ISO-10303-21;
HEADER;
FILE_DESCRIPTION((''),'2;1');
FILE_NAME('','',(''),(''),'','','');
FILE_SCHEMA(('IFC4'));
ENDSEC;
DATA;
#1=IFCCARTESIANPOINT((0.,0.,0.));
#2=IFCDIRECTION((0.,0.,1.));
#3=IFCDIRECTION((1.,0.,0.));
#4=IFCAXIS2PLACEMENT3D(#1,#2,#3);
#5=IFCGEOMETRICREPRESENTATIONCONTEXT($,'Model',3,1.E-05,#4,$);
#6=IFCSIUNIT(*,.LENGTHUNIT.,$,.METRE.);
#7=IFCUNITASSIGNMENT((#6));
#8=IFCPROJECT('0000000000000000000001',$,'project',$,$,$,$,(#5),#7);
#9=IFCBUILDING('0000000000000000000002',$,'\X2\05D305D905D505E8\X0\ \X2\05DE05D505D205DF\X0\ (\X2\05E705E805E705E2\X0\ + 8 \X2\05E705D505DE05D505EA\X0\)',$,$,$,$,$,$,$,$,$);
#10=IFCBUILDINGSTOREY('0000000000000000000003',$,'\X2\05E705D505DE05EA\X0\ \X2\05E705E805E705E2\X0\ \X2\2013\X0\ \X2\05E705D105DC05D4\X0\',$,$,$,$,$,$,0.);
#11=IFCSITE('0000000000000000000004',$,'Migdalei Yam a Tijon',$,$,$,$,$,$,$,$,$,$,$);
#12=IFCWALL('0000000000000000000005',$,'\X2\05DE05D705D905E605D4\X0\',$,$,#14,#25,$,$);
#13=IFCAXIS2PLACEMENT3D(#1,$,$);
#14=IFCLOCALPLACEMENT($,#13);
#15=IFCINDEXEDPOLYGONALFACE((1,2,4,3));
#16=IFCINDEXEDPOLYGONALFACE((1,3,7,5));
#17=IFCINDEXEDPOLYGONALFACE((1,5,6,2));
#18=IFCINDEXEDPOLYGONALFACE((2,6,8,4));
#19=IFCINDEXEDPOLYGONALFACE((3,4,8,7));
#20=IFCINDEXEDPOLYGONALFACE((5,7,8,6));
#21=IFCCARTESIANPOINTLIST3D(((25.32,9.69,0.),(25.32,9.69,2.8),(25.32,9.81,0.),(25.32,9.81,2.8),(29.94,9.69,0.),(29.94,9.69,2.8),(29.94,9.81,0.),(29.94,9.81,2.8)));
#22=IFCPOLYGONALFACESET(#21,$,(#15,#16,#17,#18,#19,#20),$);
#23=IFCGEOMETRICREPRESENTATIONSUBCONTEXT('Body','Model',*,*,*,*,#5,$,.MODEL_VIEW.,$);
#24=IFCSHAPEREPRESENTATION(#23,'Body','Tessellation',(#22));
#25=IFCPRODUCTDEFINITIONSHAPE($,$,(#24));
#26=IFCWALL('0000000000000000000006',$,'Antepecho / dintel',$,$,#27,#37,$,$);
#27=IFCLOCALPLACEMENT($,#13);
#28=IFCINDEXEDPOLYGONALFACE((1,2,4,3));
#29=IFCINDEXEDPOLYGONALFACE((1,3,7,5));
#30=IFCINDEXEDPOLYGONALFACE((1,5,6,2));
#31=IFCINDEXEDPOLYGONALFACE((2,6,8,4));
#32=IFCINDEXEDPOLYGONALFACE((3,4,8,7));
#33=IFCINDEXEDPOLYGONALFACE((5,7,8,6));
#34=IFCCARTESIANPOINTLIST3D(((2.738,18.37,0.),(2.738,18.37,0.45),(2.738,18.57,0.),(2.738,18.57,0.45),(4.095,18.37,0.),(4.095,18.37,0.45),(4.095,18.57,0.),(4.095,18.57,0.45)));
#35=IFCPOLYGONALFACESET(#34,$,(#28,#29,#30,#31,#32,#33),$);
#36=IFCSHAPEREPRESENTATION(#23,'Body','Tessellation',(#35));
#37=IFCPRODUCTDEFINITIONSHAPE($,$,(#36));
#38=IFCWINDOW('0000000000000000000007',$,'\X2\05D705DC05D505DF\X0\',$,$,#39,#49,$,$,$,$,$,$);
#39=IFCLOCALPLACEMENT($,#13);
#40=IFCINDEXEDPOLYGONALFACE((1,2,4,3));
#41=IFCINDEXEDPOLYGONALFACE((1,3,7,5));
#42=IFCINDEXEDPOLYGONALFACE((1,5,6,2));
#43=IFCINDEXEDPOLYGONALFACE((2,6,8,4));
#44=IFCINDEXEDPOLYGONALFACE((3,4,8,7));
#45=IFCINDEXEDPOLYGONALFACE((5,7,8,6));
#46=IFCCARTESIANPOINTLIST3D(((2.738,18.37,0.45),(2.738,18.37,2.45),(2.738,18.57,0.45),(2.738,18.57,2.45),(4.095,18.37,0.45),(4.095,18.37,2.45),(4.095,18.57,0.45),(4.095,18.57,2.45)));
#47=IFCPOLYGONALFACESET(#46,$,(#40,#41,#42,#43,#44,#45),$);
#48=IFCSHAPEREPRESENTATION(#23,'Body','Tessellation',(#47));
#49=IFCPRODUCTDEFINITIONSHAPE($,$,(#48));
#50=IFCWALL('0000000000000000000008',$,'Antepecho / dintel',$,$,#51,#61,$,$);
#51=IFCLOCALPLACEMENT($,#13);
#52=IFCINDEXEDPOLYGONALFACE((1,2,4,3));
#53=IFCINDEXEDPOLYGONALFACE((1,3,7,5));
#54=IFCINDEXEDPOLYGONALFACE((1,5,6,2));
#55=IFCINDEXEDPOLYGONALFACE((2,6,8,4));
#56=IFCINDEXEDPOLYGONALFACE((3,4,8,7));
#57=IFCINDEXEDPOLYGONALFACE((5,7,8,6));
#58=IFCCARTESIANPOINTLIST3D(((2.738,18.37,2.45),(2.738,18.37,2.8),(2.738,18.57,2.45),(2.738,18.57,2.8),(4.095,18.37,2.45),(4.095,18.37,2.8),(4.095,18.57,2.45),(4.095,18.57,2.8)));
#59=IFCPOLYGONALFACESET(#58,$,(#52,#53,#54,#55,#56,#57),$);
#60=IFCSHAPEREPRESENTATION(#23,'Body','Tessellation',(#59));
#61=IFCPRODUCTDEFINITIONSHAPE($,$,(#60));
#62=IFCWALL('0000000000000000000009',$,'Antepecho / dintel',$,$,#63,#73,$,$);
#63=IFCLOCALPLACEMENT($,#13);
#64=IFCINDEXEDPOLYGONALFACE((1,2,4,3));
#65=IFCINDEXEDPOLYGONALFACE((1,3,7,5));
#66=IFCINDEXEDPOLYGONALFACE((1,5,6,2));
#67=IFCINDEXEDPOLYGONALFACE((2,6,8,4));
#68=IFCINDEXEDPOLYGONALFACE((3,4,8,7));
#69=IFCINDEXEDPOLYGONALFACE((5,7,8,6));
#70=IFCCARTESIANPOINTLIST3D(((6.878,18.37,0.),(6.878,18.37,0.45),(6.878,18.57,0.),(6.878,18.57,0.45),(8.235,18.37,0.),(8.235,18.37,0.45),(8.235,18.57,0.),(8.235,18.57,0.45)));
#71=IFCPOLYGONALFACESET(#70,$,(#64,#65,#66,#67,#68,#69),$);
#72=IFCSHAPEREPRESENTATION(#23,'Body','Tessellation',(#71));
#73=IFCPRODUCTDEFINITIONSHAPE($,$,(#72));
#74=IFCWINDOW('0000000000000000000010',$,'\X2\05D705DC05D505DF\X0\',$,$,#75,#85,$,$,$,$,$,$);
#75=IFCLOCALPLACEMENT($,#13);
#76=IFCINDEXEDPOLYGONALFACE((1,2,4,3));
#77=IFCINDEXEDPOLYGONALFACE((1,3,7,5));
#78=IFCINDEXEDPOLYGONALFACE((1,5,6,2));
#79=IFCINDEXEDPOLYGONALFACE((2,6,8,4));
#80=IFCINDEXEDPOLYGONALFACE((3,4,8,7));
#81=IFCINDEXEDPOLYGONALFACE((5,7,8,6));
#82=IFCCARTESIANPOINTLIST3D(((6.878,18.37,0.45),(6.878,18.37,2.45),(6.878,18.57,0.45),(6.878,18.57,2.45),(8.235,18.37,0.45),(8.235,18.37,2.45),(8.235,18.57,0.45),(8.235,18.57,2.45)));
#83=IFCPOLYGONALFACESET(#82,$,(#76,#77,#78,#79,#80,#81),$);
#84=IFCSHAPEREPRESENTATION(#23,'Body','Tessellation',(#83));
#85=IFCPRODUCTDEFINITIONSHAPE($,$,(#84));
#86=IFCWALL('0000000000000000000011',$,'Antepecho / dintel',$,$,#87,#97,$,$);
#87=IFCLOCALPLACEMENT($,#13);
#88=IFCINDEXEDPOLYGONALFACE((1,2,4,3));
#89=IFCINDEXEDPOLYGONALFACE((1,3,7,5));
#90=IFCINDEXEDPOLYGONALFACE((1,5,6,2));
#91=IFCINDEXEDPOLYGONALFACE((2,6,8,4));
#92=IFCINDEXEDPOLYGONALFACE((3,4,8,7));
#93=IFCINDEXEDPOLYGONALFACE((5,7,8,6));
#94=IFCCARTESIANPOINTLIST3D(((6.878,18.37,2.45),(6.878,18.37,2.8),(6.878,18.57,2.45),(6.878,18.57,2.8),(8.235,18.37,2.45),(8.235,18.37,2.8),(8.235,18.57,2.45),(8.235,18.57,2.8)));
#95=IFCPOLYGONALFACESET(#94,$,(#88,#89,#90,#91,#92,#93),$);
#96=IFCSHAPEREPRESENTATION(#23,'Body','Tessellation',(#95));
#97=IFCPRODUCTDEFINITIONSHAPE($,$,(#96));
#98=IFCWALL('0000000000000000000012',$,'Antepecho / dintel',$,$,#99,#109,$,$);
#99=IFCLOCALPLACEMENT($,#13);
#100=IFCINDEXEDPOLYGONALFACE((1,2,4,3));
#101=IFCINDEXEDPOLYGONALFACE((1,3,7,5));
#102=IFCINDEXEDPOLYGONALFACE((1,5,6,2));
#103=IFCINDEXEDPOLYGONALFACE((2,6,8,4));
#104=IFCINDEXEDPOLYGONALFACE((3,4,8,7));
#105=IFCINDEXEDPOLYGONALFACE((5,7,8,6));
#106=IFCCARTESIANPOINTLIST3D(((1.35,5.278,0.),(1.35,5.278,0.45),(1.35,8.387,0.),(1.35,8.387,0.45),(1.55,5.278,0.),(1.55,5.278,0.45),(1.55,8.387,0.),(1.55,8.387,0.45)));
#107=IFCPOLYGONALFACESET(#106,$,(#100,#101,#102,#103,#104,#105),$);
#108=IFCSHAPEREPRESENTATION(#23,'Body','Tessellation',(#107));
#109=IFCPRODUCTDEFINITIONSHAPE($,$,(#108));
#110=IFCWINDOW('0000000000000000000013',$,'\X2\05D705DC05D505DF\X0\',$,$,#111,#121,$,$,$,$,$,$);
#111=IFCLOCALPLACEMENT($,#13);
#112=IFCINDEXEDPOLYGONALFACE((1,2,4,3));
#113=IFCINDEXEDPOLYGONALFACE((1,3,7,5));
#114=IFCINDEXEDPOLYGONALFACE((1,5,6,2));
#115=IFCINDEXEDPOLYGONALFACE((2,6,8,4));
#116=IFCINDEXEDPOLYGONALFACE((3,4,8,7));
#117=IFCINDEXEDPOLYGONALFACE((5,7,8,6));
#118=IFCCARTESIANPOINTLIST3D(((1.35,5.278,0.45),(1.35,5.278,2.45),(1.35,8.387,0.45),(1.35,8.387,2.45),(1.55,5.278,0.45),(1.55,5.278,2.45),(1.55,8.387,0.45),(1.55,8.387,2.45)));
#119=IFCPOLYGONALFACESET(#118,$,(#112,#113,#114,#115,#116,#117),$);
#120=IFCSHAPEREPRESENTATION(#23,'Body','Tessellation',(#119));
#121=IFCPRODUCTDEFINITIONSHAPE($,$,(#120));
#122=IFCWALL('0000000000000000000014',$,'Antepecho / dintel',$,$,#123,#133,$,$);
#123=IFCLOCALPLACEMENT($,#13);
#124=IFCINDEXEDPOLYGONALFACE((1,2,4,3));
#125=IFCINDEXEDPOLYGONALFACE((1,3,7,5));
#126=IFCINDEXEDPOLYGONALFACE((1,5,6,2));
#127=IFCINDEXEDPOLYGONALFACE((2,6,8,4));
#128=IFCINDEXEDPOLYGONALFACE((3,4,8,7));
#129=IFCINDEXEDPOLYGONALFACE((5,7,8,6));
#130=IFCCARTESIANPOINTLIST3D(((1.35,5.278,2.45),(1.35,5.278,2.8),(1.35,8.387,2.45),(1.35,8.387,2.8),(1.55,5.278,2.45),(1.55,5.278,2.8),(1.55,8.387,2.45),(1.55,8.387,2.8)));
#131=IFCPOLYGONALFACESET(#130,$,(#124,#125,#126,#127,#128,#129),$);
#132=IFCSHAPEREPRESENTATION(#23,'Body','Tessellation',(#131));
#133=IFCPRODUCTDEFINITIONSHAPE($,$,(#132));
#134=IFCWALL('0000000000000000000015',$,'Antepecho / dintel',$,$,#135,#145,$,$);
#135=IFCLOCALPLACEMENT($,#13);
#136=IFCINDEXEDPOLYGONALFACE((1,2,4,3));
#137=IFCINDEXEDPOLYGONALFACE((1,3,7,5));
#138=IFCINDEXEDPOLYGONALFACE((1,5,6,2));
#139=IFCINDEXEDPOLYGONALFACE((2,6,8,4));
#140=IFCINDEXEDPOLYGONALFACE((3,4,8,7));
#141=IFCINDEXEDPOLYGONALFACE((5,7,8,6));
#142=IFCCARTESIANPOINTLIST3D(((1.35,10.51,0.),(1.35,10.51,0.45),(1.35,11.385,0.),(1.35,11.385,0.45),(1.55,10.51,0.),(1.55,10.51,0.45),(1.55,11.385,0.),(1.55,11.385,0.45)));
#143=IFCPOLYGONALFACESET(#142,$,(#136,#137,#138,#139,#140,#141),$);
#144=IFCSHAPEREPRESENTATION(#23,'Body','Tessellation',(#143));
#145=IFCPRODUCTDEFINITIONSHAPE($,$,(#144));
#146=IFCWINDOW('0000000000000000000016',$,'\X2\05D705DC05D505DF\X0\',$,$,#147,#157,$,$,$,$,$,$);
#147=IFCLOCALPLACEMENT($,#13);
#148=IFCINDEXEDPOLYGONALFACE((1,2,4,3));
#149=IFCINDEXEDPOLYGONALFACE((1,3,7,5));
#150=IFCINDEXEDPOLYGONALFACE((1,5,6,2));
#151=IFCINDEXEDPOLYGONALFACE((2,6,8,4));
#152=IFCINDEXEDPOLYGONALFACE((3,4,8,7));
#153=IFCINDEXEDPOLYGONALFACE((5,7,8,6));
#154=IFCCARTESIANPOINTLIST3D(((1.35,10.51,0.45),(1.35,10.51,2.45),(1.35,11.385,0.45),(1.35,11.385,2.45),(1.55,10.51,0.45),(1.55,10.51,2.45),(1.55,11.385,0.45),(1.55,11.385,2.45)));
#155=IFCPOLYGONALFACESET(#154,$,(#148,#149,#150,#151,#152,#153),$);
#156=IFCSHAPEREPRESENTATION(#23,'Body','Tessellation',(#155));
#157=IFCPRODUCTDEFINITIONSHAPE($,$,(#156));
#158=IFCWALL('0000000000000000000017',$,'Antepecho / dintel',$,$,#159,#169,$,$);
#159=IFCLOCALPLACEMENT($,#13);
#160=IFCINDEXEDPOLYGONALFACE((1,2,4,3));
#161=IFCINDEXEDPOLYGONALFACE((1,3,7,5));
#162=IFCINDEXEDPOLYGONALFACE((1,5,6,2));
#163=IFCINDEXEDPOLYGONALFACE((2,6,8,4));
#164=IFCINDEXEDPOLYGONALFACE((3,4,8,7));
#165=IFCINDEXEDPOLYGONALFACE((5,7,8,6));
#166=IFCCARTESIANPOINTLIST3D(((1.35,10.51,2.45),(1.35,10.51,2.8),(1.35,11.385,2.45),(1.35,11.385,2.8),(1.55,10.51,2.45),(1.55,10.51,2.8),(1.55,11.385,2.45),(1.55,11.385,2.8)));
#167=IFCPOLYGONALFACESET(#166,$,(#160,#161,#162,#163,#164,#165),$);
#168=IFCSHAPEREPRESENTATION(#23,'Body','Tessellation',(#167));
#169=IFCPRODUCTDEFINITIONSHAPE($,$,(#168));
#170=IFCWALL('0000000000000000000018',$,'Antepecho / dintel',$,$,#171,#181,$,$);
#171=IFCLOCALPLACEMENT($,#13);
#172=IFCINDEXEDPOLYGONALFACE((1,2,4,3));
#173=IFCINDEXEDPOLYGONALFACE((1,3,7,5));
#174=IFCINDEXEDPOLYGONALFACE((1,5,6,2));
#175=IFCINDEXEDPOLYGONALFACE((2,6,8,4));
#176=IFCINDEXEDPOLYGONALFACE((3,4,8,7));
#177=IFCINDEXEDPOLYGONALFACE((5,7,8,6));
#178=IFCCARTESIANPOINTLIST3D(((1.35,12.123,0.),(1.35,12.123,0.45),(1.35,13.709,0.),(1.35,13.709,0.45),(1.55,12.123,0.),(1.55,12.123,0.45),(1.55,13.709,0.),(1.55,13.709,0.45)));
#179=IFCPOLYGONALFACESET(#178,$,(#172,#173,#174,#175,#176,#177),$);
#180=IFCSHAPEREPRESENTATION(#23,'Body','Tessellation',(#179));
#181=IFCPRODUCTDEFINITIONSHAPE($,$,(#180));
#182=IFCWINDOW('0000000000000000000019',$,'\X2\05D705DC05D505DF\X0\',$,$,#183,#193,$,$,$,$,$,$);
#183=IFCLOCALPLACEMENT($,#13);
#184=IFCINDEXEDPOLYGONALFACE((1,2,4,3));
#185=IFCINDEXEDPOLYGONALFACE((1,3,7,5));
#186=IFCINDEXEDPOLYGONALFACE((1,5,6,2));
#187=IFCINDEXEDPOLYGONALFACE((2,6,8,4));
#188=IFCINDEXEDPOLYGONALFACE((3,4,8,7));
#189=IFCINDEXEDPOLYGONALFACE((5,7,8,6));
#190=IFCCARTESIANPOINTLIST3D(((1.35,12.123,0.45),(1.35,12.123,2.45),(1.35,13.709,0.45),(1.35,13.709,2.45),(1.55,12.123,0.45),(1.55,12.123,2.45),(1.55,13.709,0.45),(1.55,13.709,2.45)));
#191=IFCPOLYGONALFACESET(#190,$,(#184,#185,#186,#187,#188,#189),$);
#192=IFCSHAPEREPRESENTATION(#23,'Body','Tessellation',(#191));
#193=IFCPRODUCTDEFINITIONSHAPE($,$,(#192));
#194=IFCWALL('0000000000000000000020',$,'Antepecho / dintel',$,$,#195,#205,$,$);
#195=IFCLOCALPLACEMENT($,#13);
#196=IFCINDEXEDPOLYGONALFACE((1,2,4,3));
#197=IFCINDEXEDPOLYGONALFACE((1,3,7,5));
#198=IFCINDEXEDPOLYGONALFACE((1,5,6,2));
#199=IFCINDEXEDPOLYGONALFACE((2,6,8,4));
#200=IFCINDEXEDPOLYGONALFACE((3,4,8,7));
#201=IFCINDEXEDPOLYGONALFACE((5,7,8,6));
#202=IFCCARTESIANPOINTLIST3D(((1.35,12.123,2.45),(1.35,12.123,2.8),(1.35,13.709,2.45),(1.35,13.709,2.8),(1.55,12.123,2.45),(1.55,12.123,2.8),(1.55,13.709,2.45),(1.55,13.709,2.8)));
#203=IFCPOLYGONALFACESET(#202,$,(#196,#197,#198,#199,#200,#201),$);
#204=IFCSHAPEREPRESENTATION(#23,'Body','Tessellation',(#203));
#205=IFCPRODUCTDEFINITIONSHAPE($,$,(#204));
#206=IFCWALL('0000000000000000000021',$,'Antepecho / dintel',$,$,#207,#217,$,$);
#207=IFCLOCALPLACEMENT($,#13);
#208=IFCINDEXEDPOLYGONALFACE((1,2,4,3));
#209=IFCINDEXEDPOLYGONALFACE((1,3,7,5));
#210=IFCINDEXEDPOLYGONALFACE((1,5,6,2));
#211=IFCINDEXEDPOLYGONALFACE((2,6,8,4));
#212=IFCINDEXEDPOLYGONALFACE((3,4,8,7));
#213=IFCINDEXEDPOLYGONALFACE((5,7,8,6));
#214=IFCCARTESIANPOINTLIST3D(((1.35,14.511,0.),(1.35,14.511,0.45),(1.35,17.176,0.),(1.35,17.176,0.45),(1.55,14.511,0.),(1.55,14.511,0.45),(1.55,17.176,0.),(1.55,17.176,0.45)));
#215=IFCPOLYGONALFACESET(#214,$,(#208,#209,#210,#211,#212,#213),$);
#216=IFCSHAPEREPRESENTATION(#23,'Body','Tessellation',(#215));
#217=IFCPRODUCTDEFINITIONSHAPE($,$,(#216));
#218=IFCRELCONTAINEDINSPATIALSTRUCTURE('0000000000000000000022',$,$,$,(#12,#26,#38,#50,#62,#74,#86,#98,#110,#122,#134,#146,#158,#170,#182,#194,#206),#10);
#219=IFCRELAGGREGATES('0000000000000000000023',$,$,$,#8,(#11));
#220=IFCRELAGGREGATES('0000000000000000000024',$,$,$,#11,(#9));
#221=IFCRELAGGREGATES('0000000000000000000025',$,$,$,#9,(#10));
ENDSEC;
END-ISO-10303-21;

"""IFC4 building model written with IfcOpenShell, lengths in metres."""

from ifc_helpers import new_model, si_unit, frame, origin_with_axes, context, subcontext, project, spatial, line, indexed_curve, outline, extrude, element, save


model = new_model("IFC4")

# Units and contexts
model_context = context("Model", 3, precision=1e-05, world=origin_with_axes())
body_context = subcontext(model_context, "Body", "Model", "MODEL_VIEW")
ifc_project = project(units=[si_unit("LENGTHUNIT", "METRE")], contexts=[model_context])

# Site, building, storey
site = spatial("IfcSite", under=ifc_project, Name="Migdalei Yam a Tijon")
building = spatial("IfcBuilding", under=site, Name="דיור מוגן (קרקע + 8 קומות)")
storey = spatial("IfcBuildingStorey", under=building, Name="קומת קרקע – קבלה", Elevation=0.0)

# Walls
element("IfcWall", 1, inside=storey, Name="מחיצה", context=body_context, shape_type="SweptSolid", body=[
    extrude(outline(indexed_curve([(0.0, 0.0), (4.62, 0.0), (4.62, 0.12), (0.0, 0.12)], segments=[line(1, 2, 3, 4, 1)])), frame((25.32, 9.69, 0.0), z_axis=(0.0, 0.0, 1.0), x_axis=(1.0, 0.0, 0.0)), (0.0, 0.0, 1.0), 2.8),
])
element("IfcWall", 2, inside=storey, Name="Antepecho / dintel", context=body_context, shape_type="SweptSolid", body=[
    extrude(outline(indexed_curve([(0.0, 0.0), (1.357, 0.0), (1.357, 0.2), (0.0, 0.2)], segments=[line(1, 2, 3, 4, 1)])), frame((2.738, 18.37, 0.0), z_axis=(0.0, 0.0, 1.0), x_axis=(1.0, 0.0, 0.0)), (0.0, 0.0, 1.0), 0.45),
])

# Window
element("IfcWindow", 3, inside=storey, Name="חלון", context=body_context, shape_type="SweptSolid", body=[
    extrude(outline(indexed_curve([(0.0, 0.0), (1.357, 0.0), (1.357, 0.2), (0.0, 0.2)], segments=[line(1, 2, 3, 4, 1)])), frame((2.738, 18.37, 0.45), z_axis=(0.0, 0.0, 1.0), x_axis=(1.0, 0.0, 0.0)), (0.0, 0.0, 1.0), 2.0),
])

# Walls
element("IfcWall", 4, inside=storey, Name="Antepecho / dintel", context=body_context, shape_type="SweptSolid", body=[
    extrude(outline(indexed_curve([(0.0, 0.0), (1.357, 0.0), (1.357, 0.2), (0.0, 0.2)], segments=[line(1, 2, 3, 4, 1)])), frame((2.738, 18.37, 2.45), z_axis=(0.0, 0.0, 1.0), x_axis=(1.0, 0.0, 0.0)), (0.0, 0.0, 1.0), 0.35),
])
element("IfcWall", 5, inside=storey, Name="Antepecho / dintel", context=body_context, shape_type="SweptSolid", body=[
    extrude(outline(indexed_curve([(0.0, 0.0), (1.357, 0.0), (1.357, 0.2), (0.0, 0.2)], segments=[line(1, 2, 3, 4, 1)])), frame((6.878, 18.37, 0.0), z_axis=(0.0, 0.0, 1.0), x_axis=(1.0, 0.0, 0.0)), (0.0, 0.0, 1.0), 0.45),
])

# Window
element("IfcWindow", 6, inside=storey, Name="חלון", context=body_context, shape_type="SweptSolid", body=[
    extrude(outline(indexed_curve([(0.0, 0.0), (1.357, 0.0), (1.357, 0.2), (0.0, 0.2)], segments=[line(1, 2, 3, 4, 1)])), frame((6.878, 18.37, 0.45), z_axis=(0.0, 0.0, 1.0), x_axis=(1.0, 0.0, 0.0)), (0.0, 0.0, 1.0), 2.0),
])

# Walls
element("IfcWall", 7, inside=storey, Name="Antepecho / dintel", context=body_context, shape_type="SweptSolid", body=[
    extrude(outline(indexed_curve([(0.0, 0.0), (1.357, 0.0), (1.357, 0.2), (0.0, 0.2)], segments=[line(1, 2, 3, 4, 1)])), frame((6.878, 18.37, 2.45), z_axis=(0.0, 0.0, 1.0), x_axis=(1.0, 0.0, 0.0)), (0.0, 0.0, 1.0), 0.35),
])
element("IfcWall", 8, inside=storey, Name="Antepecho / dintel", context=body_context, shape_type="SweptSolid", body=[
    extrude(outline(indexed_curve([(0.0, 0.0), (0.2, 0.0), (0.2, 3.109), (0.0, 3.109)], segments=[line(1, 2, 3, 4, 1)])), frame((1.35, 5.278, 0.0), z_axis=(0.0, 0.0, 1.0), x_axis=(1.0, 0.0, 0.0)), (0.0, 0.0, 1.0), 0.45),
])

# Window
element("IfcWindow", 9, inside=storey, Name="חלון", context=body_context, shape_type="SweptSolid", body=[
    extrude(outline(indexed_curve([(0.0, 0.0), (0.2, 0.0), (0.2, 3.109), (0.0, 3.109)], segments=[line(1, 2, 3, 4, 1)])), frame((1.35, 5.278, 0.45), z_axis=(0.0, 0.0, 1.0), x_axis=(1.0, 0.0, 0.0)), (0.0, 0.0, 1.0), 2.0),
])

# Walls
element("IfcWall", 10, inside=storey, Name="Antepecho / dintel", context=body_context, shape_type="SweptSolid", body=[
    extrude(outline(indexed_curve([(0.0, 0.0), (0.2, 0.0), (0.2, 3.109), (0.0, 3.109)], segments=[line(1, 2, 3, 4, 1)])), frame((1.35, 5.278, 2.45), z_axis=(0.0, 0.0, 1.0), x_axis=(1.0, 0.0, 0.0)), (0.0, 0.0, 1.0), 0.35),
])
element("IfcWall", 11, inside=storey, Name="Antepecho / dintel", context=body_context, shape_type="SweptSolid", body=[
    extrude(outline(indexed_curve([(0.0, 0.0), (0.2, 0.0), (0.2, 0.875), (0.0, 0.875)], segments=[line(1, 2, 3, 4, 1)])), frame((1.35, 10.51, 0.0), z_axis=(0.0, 0.0, 1.0), x_axis=(1.0, 0.0, 0.0)), (0.0, 0.0, 1.0), 0.45),
])

# Window
element("IfcWindow", 12, inside=storey, Name="חלון", context=body_context, shape_type="SweptSolid", body=[
    extrude(outline(indexed_curve([(0.0, 0.0), (0.2, 0.0), (0.2, 0.875), (0.0, 0.875)], segments=[line(1, 2, 3, 4, 1)])), frame((1.35, 10.51, 0.45), z_axis=(0.0, 0.0, 1.0), x_axis=(1.0, 0.0, 0.0)), (0.0, 0.0, 1.0), 2.0),
])

# Walls
element("IfcWall", 13, inside=storey, Name="Antepecho / dintel", context=body_context, shape_type="SweptSolid", body=[
    extrude(outline(indexed_curve([(0.0, 0.0), (0.2, 0.0), (0.2, 0.875), (0.0, 0.875)], segments=[line(1, 2, 3, 4, 1)])), frame((1.35, 10.51, 2.45), z_axis=(0.0, 0.0, 1.0), x_axis=(1.0, 0.0, 0.0)), (0.0, 0.0, 1.0), 0.35),
])
element("IfcWall", 14, inside=storey, Name="Antepecho / dintel", context=body_context, shape_type="SweptSolid", body=[
    extrude(outline(indexed_curve([(0.0, 0.0), (0.2, 0.0), (0.2, 1.586), (0.0, 1.586)], segments=[line(1, 2, 3, 4, 1)])), frame((1.35, 12.123, 0.0), z_axis=(0.0, 0.0, 1.0), x_axis=(1.0, 0.0, 0.0)), (0.0, 0.0, 1.0), 0.45),
])

# Window
element("IfcWindow", 15, inside=storey, Name="חלון", context=body_context, shape_type="SweptSolid", body=[
    extrude(outline(indexed_curve([(0.0, 0.0), (0.2, 0.0), (0.2, 1.586), (0.0, 1.586)], segments=[line(1, 2, 3, 4, 1)])), frame((1.35, 12.123, 0.45), z_axis=(0.0, 0.0, 1.0), x_axis=(1.0, 0.0, 0.0)), (0.0, 0.0, 1.0), 2.0),
])

# Walls
element("IfcWall", 16, inside=storey, Name="Antepecho / dintel", context=body_context, shape_type="SweptSolid", body=[
    extrude(outline(indexed_curve([(0.0, 0.0), (0.2, 0.0), (0.2, 1.586), (0.0, 1.586)], segments=[line(1, 2, 3, 4, 1)])), frame((1.35, 12.123, 2.45), z_axis=(0.0, 0.0, 1.0), x_axis=(1.0, 0.0, 0.0)), (0.0, 0.0, 1.0), 0.35),
])
element("IfcWall", 17, inside=storey, Name="Antepecho / dintel", context=body_context, shape_type="SweptSolid", body=[
    extrude(outline(indexed_curve([(0.0, 0.0), (0.2, 0.0), (0.2, 2.665), (0.0, 2.665)], segments=[line(1, 2, 3, 4, 1)])), frame((1.35, 14.511, 0.0), z_axis=(0.0, 0.0, 1.0), x_axis=(1.0, 0.0, 0.0)), (0.0, 0.0, 1.0), 0.45),
])

save(model, "model.ifc")
